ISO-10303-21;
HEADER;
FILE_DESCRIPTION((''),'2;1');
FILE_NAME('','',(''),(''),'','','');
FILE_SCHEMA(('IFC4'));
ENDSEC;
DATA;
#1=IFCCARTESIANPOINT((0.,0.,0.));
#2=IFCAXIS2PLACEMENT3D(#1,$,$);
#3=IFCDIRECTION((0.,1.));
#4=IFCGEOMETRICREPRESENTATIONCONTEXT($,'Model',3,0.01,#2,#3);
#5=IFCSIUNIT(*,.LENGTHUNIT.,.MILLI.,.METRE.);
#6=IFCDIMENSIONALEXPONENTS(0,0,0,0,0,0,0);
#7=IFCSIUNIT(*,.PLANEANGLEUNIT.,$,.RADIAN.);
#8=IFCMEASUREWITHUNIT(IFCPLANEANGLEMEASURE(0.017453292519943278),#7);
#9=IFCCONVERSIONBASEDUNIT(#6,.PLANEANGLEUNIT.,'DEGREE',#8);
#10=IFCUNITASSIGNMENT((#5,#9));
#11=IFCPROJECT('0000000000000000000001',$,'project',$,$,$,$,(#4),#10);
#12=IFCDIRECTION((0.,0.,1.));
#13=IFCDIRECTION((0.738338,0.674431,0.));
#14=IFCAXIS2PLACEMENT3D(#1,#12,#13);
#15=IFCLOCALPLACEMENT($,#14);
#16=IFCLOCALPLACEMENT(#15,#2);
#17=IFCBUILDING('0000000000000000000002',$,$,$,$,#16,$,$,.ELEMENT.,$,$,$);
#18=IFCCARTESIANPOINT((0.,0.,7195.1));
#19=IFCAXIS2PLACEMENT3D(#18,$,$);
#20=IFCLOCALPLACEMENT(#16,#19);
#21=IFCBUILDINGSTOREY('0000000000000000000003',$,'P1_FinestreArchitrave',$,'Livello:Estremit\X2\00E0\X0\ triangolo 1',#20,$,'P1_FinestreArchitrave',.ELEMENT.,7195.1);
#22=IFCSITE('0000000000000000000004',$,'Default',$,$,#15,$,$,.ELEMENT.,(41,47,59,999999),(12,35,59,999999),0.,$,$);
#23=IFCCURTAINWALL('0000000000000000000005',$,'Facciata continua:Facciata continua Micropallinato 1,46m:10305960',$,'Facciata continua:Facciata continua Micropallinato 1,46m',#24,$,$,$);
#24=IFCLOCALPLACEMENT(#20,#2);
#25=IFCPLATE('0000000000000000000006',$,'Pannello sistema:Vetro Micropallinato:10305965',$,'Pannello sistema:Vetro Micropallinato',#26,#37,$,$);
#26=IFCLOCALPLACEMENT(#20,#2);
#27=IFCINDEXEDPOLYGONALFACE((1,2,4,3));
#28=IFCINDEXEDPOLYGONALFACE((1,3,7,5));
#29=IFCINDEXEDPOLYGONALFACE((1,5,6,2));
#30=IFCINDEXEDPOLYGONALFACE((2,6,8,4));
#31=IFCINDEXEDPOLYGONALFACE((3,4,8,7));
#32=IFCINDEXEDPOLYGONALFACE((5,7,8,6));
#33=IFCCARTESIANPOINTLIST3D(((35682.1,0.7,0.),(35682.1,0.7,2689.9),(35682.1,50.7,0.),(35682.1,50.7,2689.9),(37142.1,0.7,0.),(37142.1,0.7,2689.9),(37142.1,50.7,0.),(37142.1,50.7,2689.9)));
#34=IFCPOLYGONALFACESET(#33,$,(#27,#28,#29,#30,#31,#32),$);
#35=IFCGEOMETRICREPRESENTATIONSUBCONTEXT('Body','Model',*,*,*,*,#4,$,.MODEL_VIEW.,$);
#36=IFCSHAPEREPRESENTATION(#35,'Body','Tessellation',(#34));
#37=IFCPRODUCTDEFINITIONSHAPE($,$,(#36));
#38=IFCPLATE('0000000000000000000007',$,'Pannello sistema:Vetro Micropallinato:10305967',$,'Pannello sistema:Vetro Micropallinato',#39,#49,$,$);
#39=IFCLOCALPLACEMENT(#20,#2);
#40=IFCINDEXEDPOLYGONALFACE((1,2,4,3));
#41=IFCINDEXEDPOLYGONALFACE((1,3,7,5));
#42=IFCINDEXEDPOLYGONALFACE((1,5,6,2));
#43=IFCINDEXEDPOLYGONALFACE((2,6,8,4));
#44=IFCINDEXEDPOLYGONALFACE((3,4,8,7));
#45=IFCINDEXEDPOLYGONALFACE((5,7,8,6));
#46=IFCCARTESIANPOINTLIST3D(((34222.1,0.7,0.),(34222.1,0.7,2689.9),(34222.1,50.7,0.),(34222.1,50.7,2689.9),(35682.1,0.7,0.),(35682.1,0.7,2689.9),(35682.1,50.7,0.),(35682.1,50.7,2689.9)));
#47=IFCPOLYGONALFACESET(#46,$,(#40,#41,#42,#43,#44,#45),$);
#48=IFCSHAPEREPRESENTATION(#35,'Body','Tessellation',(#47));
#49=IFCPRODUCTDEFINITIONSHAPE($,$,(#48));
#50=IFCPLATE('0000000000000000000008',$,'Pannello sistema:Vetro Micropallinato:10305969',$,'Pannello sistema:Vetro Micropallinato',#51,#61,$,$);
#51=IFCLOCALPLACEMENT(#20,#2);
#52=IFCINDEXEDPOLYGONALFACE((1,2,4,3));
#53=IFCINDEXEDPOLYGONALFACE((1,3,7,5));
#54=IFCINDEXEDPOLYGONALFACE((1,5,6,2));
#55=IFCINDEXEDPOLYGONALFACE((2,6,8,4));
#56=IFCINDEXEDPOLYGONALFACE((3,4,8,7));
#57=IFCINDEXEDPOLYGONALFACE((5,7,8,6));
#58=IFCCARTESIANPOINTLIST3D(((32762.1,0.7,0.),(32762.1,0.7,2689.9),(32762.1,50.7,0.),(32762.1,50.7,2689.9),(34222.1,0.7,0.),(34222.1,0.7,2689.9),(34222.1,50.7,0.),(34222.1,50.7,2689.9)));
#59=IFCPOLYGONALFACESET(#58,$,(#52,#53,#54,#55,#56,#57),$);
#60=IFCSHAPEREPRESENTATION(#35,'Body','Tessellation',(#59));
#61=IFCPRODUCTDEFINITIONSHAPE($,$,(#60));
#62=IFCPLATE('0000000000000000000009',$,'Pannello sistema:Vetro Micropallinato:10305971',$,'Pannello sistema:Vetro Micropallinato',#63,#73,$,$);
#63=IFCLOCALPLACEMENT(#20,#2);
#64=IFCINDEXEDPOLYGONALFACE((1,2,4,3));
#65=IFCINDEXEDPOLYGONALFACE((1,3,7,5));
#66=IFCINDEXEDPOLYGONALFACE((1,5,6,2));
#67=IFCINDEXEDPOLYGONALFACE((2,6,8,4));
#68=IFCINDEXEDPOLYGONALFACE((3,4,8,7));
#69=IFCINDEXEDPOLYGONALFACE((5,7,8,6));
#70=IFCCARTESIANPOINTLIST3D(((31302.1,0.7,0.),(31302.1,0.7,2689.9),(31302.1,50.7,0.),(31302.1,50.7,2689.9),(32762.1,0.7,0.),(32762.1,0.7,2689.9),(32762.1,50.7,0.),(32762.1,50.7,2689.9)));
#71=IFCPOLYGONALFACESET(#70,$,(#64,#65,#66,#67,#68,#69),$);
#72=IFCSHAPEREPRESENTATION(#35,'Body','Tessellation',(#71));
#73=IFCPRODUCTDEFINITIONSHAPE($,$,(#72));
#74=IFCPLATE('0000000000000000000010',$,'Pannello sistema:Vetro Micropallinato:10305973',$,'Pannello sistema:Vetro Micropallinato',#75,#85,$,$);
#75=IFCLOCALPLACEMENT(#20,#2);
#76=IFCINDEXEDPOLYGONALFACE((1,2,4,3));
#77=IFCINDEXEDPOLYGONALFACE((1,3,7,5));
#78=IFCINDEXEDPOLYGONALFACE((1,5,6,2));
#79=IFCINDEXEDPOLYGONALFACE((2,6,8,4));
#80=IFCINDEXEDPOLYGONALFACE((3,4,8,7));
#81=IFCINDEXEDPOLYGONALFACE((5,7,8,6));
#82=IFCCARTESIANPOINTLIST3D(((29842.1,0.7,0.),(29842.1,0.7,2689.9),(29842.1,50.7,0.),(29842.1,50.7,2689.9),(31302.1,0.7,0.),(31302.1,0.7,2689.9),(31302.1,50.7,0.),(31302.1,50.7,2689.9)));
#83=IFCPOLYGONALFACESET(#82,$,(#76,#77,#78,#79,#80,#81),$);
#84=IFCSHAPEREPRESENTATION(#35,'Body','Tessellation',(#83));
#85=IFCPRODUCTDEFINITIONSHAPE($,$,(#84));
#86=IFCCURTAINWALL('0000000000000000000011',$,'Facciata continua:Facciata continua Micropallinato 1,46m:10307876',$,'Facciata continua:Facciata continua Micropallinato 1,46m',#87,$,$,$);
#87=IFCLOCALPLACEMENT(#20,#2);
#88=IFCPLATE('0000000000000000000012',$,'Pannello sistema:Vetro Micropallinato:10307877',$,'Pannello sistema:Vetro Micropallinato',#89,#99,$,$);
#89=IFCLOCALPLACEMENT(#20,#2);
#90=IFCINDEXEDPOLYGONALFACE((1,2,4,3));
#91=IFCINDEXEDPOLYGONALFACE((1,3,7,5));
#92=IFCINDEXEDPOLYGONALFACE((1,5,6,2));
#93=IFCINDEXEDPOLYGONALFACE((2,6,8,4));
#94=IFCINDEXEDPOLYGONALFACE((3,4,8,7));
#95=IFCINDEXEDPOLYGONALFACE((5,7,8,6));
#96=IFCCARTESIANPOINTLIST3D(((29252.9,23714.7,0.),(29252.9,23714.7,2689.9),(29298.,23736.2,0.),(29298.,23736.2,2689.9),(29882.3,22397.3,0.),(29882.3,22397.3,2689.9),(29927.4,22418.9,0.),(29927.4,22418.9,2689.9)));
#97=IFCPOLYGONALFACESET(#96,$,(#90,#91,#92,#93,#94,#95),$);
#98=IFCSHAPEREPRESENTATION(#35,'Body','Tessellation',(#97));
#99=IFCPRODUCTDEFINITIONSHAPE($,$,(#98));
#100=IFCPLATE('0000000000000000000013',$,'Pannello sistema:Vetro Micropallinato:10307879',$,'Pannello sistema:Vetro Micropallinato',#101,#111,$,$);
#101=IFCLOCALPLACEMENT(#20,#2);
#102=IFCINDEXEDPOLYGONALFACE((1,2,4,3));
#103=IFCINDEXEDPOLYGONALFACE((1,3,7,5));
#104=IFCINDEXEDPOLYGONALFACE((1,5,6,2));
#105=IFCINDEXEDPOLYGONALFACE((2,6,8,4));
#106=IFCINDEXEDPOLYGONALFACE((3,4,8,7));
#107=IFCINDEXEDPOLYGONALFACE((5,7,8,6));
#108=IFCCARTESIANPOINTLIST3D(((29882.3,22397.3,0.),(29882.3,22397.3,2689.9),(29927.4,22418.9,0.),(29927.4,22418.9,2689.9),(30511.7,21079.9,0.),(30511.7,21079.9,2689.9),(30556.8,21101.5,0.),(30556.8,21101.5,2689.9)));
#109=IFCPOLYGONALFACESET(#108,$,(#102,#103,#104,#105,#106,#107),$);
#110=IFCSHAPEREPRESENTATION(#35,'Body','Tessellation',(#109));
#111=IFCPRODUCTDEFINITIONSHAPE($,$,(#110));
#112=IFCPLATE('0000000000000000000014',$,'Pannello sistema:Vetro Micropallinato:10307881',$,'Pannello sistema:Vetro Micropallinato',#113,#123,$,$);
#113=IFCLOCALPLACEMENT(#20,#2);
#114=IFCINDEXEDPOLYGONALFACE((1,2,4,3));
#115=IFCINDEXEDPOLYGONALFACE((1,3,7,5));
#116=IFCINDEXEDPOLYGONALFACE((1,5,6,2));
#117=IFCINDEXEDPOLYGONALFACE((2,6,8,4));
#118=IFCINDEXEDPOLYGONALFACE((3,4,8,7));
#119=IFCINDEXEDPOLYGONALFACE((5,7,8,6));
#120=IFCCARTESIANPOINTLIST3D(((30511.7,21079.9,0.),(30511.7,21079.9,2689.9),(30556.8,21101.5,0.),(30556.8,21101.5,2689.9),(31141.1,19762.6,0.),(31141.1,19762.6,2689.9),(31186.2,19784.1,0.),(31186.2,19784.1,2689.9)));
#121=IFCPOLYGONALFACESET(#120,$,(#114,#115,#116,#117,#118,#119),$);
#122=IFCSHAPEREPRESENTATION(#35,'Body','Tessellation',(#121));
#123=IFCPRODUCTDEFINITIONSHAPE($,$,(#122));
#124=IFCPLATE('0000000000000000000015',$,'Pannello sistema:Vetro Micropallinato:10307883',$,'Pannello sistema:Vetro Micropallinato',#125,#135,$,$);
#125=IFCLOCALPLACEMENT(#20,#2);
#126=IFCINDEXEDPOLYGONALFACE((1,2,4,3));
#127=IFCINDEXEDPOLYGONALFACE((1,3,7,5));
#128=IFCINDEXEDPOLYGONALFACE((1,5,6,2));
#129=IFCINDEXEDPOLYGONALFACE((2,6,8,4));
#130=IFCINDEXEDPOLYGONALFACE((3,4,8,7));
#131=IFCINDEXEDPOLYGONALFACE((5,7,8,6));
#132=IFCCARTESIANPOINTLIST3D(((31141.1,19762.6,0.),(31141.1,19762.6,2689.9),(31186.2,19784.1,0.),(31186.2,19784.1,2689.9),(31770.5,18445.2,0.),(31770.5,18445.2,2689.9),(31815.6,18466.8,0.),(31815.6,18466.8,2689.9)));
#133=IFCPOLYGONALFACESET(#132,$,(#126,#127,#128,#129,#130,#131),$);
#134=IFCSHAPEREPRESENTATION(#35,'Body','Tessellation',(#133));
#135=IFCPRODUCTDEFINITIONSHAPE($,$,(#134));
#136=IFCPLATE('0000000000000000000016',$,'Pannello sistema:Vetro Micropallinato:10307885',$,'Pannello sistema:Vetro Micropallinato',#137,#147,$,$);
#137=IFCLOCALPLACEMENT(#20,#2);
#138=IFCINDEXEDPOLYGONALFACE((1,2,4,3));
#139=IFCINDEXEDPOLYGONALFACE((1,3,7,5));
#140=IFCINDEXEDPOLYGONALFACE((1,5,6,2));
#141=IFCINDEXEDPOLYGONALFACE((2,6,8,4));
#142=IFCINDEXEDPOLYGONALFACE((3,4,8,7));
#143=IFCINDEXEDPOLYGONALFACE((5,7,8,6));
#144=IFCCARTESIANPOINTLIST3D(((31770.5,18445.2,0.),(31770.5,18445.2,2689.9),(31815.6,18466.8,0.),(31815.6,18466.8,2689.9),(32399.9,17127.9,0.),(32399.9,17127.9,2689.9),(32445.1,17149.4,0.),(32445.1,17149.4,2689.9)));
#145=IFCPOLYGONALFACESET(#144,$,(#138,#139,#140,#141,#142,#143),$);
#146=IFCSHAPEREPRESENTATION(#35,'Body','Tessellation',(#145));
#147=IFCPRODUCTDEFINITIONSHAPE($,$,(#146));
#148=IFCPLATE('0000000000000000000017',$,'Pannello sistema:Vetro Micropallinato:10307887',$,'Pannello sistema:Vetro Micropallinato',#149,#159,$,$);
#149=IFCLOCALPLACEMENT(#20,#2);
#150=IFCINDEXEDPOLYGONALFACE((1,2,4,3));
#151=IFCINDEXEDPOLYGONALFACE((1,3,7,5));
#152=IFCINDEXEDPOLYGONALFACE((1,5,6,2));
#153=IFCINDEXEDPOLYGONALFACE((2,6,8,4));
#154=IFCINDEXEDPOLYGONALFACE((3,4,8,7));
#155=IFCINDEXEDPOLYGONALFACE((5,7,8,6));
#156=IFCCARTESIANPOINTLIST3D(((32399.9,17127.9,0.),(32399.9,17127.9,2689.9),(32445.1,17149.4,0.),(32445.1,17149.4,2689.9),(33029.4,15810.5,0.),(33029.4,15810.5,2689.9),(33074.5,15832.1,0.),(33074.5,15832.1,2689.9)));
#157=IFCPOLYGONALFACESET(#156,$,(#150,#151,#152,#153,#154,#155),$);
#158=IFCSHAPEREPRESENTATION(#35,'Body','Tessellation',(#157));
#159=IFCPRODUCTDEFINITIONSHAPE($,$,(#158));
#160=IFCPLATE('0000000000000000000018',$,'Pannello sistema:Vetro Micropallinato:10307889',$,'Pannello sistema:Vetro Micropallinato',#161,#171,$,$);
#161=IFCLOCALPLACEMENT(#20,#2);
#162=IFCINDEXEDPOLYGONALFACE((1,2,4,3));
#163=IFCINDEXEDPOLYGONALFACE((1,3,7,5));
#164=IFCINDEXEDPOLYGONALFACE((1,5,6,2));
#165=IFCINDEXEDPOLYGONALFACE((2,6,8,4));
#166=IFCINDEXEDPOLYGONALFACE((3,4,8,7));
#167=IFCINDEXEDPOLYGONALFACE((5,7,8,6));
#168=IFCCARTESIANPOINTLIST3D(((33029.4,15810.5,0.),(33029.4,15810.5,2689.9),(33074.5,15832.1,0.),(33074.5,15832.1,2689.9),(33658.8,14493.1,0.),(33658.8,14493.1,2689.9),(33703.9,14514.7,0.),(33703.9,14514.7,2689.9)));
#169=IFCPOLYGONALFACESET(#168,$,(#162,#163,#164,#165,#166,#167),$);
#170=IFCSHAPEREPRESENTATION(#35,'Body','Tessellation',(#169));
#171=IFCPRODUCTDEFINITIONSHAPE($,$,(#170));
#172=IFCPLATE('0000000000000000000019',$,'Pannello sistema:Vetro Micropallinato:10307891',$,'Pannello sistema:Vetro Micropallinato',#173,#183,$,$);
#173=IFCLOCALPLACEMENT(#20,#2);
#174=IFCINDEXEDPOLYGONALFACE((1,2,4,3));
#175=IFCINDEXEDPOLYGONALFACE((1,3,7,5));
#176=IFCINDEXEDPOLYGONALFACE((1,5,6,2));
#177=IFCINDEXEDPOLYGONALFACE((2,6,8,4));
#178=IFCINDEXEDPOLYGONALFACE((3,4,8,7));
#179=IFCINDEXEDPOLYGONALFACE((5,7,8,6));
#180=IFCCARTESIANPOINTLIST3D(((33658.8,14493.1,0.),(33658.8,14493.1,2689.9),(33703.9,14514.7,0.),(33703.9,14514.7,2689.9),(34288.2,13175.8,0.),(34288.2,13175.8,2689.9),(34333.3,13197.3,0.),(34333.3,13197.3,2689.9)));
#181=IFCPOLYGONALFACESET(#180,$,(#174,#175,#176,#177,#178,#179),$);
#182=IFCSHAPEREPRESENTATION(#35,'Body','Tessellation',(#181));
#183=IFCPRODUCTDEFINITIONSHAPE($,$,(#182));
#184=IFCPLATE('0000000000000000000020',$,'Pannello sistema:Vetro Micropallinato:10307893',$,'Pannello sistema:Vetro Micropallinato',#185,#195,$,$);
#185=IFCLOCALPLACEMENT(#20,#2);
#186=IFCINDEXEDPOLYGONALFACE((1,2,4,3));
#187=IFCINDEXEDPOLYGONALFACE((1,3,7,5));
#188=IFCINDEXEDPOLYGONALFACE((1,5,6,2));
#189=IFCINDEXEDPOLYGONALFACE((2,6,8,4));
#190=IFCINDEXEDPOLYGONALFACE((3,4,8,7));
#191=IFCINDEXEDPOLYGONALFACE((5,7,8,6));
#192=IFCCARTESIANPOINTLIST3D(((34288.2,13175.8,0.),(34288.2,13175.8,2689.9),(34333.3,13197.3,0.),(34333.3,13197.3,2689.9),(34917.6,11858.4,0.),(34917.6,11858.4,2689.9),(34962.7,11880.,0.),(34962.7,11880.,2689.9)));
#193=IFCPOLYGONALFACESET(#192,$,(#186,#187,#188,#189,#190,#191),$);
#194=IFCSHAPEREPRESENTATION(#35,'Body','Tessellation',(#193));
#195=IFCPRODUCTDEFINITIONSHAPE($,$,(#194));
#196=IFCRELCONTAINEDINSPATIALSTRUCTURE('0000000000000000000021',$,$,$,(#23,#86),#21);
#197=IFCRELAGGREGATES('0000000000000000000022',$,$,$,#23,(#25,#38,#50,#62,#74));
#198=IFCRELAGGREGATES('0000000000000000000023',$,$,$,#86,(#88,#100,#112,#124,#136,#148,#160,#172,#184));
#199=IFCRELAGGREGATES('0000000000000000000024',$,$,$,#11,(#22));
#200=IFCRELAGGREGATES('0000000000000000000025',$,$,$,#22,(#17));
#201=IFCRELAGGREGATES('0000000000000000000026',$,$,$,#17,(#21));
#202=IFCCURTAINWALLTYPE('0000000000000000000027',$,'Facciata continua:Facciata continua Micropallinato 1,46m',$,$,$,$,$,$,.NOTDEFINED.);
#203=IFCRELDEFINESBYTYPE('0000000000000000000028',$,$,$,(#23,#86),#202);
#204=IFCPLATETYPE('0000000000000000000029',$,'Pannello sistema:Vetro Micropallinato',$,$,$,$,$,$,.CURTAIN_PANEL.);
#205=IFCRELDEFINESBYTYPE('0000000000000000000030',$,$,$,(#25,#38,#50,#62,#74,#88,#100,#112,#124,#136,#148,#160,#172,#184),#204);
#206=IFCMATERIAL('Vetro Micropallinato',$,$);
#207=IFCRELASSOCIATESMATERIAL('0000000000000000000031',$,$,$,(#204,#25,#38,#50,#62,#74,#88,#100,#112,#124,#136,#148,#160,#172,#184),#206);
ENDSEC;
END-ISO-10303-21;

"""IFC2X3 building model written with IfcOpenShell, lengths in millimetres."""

from ifc_helpers import new_model, entity, si_unit, converted_unit, direction, frame, origin, origin_2d_with_axis, place, context, subcontext, project, spatial, rectangle, extrude, source, transform, mapped, material, type_object, type_shapes, element, aggregate, save


model = new_model("IFC2X3")

# Units and contexts
model_context = context("Model", 3, precision=0.01, world=origin(), true_north=direction((0.0, 1.0)))
body_context = subcontext(model_context, "Body", "Model", "MODEL_VIEW")
ifc_project = project(units=[si_unit("LENGTHUNIT", "METRE", prefix="MILLI"), converted_unit("PLANEANGLEUNIT", "DEGREE", entity("IfcPlaneAngleMeasure", 0.017453292519943278), si_unit("PLANEANGLEUNIT", "RADIAN"), dimensions=[0, 0, 0, 0, 0, 0, 0])], contexts=[model_context])

# Site, building, storey
site_placement = place(None, frame((0.0, 0.0, 0.0), z_axis=(0.0, 0.0, 1.0), x_axis=(0.738338, 0.674431, 0.0)))
site = spatial("IfcSite", under=ifc_project, at=site_placement, Name="Default", CompositionType="ELEMENT", RefLatitude=(41, 47, 59, 999999), RefLongitude=(12, 35, 59, 999999), RefElevation=0.0)
building_placement = place(site_placement, origin())
building = spatial("IfcBuilding", under=site, at=building_placement, CompositionType="ELEMENT")
storey_placement = place(building_placement, frame((0.0, 0.0, 7195.1)))
storey = spatial("IfcBuildingStorey", under=building, at=storey_placement, Name="P1_FinestreArchitrave", ObjectType="Livello:Estremità triangolo 1", LongName="P1_FinestreArchitrave", CompositionType="ELEMENT", Elevation=7195.1)

# Curtain walls, plates
curtain_wall_type = type_object("IfcCurtainWallType", Name="Facciata continua:Facciata continua Micropallinato 1,46m", PredefinedType="NOTDEFINED")
ifc_material = material(Name="Vetro Micropallinato")
plate_type_1 = type_object("IfcPlateType", Name="Pannello sistema:Vetro Micropallinato", PredefinedType="CURTAIN_PANEL", material=ifc_material)
shared_shape_1 = source(origin(), body_context, "Body", "SweptSolid", [
    extrude(rectangle(XDim=50.0, YDim=1460.0, at=origin_2d_with_axis()), frame((0.0, -25.0, 0.0), z_axis=(0.0, 0.0, 1.0), x_axis=(0.0, 1.0, 0.0)), (0.0, 0.0, 1.0), 2689.9),
])
type_shapes(plate_type_1, [shared_shape_1])
curtain_wall_1_placement = place(storey_placement, frame((0.0, 0.0, -7195.1)))
curtain_wall_1 = element("IfcCurtainWall", 1, at=curtain_wall_1_placement, inside=storey, type_object=curtain_wall_type, Name="Facciata continua:Facciata continua Micropallinato 1,46m:10305960", ObjectType="Facciata continua:Facciata continua Micropallinato 1,46m")
plate_1_placement = place(curtain_wall_1_placement, frame((36412.1, 0.7, 7195.1), z_axis=(0.0, 0.0, 1.0), x_axis=(-1.0, 0.0, 0.0)))
plate_1 = element("IfcPlate", 2, at=plate_1_placement, type_object=plate_type_1, material=ifc_material, Name="Pannello sistema:Vetro Micropallinato:10305965", ObjectType="Pannello sistema:Vetro Micropallinato", context=body_context, shape_type="MappedRepresentation", body=[
    mapped(shared_shape_1, transform((0.0, 0.0, 0.0), scale=1.0)),
])
plate_2_placement = place(curtain_wall_1_placement, frame((34952.1, 0.7, 7195.1), z_axis=(0.0, 0.0, 1.0), x_axis=(-1.0, 0.0, 0.0)))
plate_2 = element("IfcPlate", 3, at=plate_2_placement, type_object=plate_type_1, material=ifc_material, Name="Pannello sistema:Vetro Micropallinato:10305967", ObjectType="Pannello sistema:Vetro Micropallinato", context=body_context, shape_type="MappedRepresentation", body=[
    mapped(shared_shape_1, transform((0.0, 0.0, 0.0), scale=1.0)),
])
plate_3_placement = place(curtain_wall_1_placement, frame((33492.1, 0.7, 7195.1), z_axis=(0.0, 0.0, 1.0), x_axis=(-1.0, 0.0, 0.0)))
plate_3 = element("IfcPlate", 4, at=plate_3_placement, type_object=plate_type_1, material=ifc_material, Name="Pannello sistema:Vetro Micropallinato:10305969", ObjectType="Pannello sistema:Vetro Micropallinato", context=body_context, shape_type="MappedRepresentation", body=[
    mapped(shared_shape_1, transform((0.0, 0.0, 0.0), scale=1.0)),
])
plate_4_placement = place(curtain_wall_1_placement, frame((32032.1, 0.7, 7195.1), z_axis=(0.0, 0.0, 1.0), x_axis=(-1.0, 0.0, 0.0)))
plate_4 = element("IfcPlate", 5, at=plate_4_placement, type_object=plate_type_1, material=ifc_material, Name="Pannello sistema:Vetro Micropallinato:10305971", ObjectType="Pannello sistema:Vetro Micropallinato", context=body_context, shape_type="MappedRepresentation", body=[
    mapped(shared_shape_1, transform((0.0, 0.0, 0.0), scale=1.0)),
])
plate_5_placement = place(curtain_wall_1_placement, frame((30572.1, 0.7, 7195.1), z_axis=(0.0, 0.0, 1.0), x_axis=(-1.0, 0.0, 0.0)))
plate_5 = element("IfcPlate", 6, at=plate_5_placement, type_object=plate_type_1, material=ifc_material, Name="Pannello sistema:Vetro Micropallinato:10305973", ObjectType="Pannello sistema:Vetro Micropallinato", context=body_context, shape_type="MappedRepresentation", body=[
    mapped(shared_shape_1, transform((0.0, 0.0, 0.0), scale=1.0)),
])
curtain_wall_2_placement = place(storey_placement, frame((0.0, 0.0, -7195.1)))
curtain_wall_2 = element("IfcCurtainWall", 7, at=curtain_wall_2_placement, inside=storey, type_object=curtain_wall_type, Name="Facciata continua:Facciata continua Micropallinato 1,46m:10307876", ObjectType="Facciata continua:Facciata continua Micropallinato 1,46m")
plate_6_placement = place(curtain_wall_2_placement, frame((29612.7, 23077.5, 7195.1), z_axis=(0.0, 0.0, 1.0), x_axis=(0.431105, -0.902302, 0.0)))
plate_6 = element("IfcPlate", 8, at=plate_6_placement, type_object=plate_type_1, material=ifc_material, Name="Pannello sistema:Vetro Micropallinato:10307877", ObjectType="Pannello sistema:Vetro Micropallinato", context=body_context, shape_type="MappedRepresentation", body=[
    mapped(shared_shape_1, transform((0.0, 0.0, 0.0), scale=1.0)),
])
plate_7_placement = place(curtain_wall_2_placement, frame((30242.1, 21760.2, 7195.1), z_axis=(0.0, 0.0, 1.0), x_axis=(0.431105, -0.902302, 0.0)))
plate_7 = element("IfcPlate", 9, at=plate_7_placement, type_object=plate_type_1, material=ifc_material, Name="Pannello sistema:Vetro Micropallinato:10307879", ObjectType="Pannello sistema:Vetro Micropallinato", context=body_context, shape_type="MappedRepresentation", body=[
    mapped(shared_shape_1, transform((0.0, 0.0, 0.0), scale=1.0)),
])
plate_8_placement = place(curtain_wall_2_placement, frame((30871.5, 20442.8, 7195.1), z_axis=(0.0, 0.0, 1.0), x_axis=(0.431105, -0.902302, 0.0)))
plate_8 = element("IfcPlate", 10, at=plate_8_placement, type_object=plate_type_1, material=ifc_material, Name="Pannello sistema:Vetro Micropallinato:10307881", ObjectType="Pannello sistema:Vetro Micropallinato", context=body_context, shape_type="MappedRepresentation", body=[
    mapped(shared_shape_1, transform((0.0, 0.0, 0.0), scale=1.0)),
])
plate_9_placement = place(curtain_wall_2_placement, frame((31500.9, 19125.5, 7195.1), z_axis=(0.0, 0.0, 1.0), x_axis=(0.431105, -0.902302, 0.0)))
plate_9 = element("IfcPlate", 11, at=plate_9_placement, type_object=plate_type_1, material=ifc_material, Name="Pannello sistema:Vetro Micropallinato:10307883", ObjectType="Pannello sistema:Vetro Micropallinato", context=body_context, shape_type="MappedRepresentation", body=[
    mapped(shared_shape_1, transform((0.0, 0.0, 0.0), scale=1.0)),
])
plate_10_placement = place(curtain_wall_2_placement, frame((32130.3, 17808.1, 7195.1), z_axis=(0.0, 0.0, 1.0), x_axis=(0.431105, -0.902302, 0.0)))
plate_10 = element("IfcPlate", 12, at=plate_10_placement, type_object=plate_type_1, material=ifc_material, Name="Pannello sistema:Vetro Micropallinato:10307885", ObjectType="Pannello sistema:Vetro Micropallinato", context=body_context, shape_type="MappedRepresentation", body=[
    mapped(shared_shape_1, transform((0.0, 0.0, 0.0), scale=1.0)),
])
plate_11_placement = place(curtain_wall_2_placement, frame((32759.8, 16490.7, 7195.1), z_axis=(0.0, 0.0, 1.0), x_axis=(0.431105, -0.902302, 0.0)))
plate_11 = element("IfcPlate", 13, at=plate_11_placement, type_object=plate_type_1, material=ifc_material, Name="Pannello sistema:Vetro Micropallinato:10307887", ObjectType="Pannello sistema:Vetro Micropallinato", context=body_context, shape_type="MappedRepresentation", body=[
    mapped(shared_shape_1, transform((0.0, 0.0, 0.0), scale=1.0)),
])
plate_12_placement = place(curtain_wall_2_placement, frame((33389.2, 15173.4, 7195.1), z_axis=(0.0, 0.0, 1.0), x_axis=(0.431105, -0.902302, 0.0)))
plate_12 = element("IfcPlate", 14, at=plate_12_placement, type_object=plate_type_1, material=ifc_material, Name="Pannello sistema:Vetro Micropallinato:10307889", ObjectType="Pannello sistema:Vetro Micropallinato", context=body_context, shape_type="MappedRepresentation", body=[
    mapped(shared_shape_1, transform((0.0, 0.0, 0.0), scale=1.0)),
])
plate_13_placement = place(curtain_wall_2_placement, frame((34018.6, 13856.0, 7195.1), z_axis=(0.0, 0.0, 1.0), x_axis=(0.431105, -0.902302, 0.0)))
plate_13 = element("IfcPlate", 15, at=plate_13_placement, type_object=plate_type_1, material=ifc_material, Name="Pannello sistema:Vetro Micropallinato:10307891", ObjectType="Pannello sistema:Vetro Micropallinato", context=body_context, shape_type="MappedRepresentation", body=[
    mapped(shared_shape_1, transform((0.0, 0.0, 0.0), scale=1.0)),
])
plate_14_placement = place(curtain_wall_2_placement, frame((34648.0, 12538.7, 7195.1), z_axis=(0.0, 0.0, 1.0), x_axis=(0.431105, -0.902302, 0.0)))
plate_14 = element("IfcPlate", 16, at=plate_14_placement, type_object=plate_type_1, material=ifc_material, Name="Pannello sistema:Vetro Micropallinato:10307893", ObjectType="Pannello sistema:Vetro Micropallinato", context=body_context, shape_type="MappedRepresentation", body=[
    mapped(shared_shape_1, transform((0.0, 0.0, 0.0), scale=1.0)),
])

aggregate(curtain_wall_1, [plate_1, plate_2, plate_3, plate_4, plate_5])
aggregate(curtain_wall_2, [plate_6, plate_7, plate_8, plate_9, plate_10, plate_11, plate_12, plate_13, plate_14])

save(model, "model.ifc")
